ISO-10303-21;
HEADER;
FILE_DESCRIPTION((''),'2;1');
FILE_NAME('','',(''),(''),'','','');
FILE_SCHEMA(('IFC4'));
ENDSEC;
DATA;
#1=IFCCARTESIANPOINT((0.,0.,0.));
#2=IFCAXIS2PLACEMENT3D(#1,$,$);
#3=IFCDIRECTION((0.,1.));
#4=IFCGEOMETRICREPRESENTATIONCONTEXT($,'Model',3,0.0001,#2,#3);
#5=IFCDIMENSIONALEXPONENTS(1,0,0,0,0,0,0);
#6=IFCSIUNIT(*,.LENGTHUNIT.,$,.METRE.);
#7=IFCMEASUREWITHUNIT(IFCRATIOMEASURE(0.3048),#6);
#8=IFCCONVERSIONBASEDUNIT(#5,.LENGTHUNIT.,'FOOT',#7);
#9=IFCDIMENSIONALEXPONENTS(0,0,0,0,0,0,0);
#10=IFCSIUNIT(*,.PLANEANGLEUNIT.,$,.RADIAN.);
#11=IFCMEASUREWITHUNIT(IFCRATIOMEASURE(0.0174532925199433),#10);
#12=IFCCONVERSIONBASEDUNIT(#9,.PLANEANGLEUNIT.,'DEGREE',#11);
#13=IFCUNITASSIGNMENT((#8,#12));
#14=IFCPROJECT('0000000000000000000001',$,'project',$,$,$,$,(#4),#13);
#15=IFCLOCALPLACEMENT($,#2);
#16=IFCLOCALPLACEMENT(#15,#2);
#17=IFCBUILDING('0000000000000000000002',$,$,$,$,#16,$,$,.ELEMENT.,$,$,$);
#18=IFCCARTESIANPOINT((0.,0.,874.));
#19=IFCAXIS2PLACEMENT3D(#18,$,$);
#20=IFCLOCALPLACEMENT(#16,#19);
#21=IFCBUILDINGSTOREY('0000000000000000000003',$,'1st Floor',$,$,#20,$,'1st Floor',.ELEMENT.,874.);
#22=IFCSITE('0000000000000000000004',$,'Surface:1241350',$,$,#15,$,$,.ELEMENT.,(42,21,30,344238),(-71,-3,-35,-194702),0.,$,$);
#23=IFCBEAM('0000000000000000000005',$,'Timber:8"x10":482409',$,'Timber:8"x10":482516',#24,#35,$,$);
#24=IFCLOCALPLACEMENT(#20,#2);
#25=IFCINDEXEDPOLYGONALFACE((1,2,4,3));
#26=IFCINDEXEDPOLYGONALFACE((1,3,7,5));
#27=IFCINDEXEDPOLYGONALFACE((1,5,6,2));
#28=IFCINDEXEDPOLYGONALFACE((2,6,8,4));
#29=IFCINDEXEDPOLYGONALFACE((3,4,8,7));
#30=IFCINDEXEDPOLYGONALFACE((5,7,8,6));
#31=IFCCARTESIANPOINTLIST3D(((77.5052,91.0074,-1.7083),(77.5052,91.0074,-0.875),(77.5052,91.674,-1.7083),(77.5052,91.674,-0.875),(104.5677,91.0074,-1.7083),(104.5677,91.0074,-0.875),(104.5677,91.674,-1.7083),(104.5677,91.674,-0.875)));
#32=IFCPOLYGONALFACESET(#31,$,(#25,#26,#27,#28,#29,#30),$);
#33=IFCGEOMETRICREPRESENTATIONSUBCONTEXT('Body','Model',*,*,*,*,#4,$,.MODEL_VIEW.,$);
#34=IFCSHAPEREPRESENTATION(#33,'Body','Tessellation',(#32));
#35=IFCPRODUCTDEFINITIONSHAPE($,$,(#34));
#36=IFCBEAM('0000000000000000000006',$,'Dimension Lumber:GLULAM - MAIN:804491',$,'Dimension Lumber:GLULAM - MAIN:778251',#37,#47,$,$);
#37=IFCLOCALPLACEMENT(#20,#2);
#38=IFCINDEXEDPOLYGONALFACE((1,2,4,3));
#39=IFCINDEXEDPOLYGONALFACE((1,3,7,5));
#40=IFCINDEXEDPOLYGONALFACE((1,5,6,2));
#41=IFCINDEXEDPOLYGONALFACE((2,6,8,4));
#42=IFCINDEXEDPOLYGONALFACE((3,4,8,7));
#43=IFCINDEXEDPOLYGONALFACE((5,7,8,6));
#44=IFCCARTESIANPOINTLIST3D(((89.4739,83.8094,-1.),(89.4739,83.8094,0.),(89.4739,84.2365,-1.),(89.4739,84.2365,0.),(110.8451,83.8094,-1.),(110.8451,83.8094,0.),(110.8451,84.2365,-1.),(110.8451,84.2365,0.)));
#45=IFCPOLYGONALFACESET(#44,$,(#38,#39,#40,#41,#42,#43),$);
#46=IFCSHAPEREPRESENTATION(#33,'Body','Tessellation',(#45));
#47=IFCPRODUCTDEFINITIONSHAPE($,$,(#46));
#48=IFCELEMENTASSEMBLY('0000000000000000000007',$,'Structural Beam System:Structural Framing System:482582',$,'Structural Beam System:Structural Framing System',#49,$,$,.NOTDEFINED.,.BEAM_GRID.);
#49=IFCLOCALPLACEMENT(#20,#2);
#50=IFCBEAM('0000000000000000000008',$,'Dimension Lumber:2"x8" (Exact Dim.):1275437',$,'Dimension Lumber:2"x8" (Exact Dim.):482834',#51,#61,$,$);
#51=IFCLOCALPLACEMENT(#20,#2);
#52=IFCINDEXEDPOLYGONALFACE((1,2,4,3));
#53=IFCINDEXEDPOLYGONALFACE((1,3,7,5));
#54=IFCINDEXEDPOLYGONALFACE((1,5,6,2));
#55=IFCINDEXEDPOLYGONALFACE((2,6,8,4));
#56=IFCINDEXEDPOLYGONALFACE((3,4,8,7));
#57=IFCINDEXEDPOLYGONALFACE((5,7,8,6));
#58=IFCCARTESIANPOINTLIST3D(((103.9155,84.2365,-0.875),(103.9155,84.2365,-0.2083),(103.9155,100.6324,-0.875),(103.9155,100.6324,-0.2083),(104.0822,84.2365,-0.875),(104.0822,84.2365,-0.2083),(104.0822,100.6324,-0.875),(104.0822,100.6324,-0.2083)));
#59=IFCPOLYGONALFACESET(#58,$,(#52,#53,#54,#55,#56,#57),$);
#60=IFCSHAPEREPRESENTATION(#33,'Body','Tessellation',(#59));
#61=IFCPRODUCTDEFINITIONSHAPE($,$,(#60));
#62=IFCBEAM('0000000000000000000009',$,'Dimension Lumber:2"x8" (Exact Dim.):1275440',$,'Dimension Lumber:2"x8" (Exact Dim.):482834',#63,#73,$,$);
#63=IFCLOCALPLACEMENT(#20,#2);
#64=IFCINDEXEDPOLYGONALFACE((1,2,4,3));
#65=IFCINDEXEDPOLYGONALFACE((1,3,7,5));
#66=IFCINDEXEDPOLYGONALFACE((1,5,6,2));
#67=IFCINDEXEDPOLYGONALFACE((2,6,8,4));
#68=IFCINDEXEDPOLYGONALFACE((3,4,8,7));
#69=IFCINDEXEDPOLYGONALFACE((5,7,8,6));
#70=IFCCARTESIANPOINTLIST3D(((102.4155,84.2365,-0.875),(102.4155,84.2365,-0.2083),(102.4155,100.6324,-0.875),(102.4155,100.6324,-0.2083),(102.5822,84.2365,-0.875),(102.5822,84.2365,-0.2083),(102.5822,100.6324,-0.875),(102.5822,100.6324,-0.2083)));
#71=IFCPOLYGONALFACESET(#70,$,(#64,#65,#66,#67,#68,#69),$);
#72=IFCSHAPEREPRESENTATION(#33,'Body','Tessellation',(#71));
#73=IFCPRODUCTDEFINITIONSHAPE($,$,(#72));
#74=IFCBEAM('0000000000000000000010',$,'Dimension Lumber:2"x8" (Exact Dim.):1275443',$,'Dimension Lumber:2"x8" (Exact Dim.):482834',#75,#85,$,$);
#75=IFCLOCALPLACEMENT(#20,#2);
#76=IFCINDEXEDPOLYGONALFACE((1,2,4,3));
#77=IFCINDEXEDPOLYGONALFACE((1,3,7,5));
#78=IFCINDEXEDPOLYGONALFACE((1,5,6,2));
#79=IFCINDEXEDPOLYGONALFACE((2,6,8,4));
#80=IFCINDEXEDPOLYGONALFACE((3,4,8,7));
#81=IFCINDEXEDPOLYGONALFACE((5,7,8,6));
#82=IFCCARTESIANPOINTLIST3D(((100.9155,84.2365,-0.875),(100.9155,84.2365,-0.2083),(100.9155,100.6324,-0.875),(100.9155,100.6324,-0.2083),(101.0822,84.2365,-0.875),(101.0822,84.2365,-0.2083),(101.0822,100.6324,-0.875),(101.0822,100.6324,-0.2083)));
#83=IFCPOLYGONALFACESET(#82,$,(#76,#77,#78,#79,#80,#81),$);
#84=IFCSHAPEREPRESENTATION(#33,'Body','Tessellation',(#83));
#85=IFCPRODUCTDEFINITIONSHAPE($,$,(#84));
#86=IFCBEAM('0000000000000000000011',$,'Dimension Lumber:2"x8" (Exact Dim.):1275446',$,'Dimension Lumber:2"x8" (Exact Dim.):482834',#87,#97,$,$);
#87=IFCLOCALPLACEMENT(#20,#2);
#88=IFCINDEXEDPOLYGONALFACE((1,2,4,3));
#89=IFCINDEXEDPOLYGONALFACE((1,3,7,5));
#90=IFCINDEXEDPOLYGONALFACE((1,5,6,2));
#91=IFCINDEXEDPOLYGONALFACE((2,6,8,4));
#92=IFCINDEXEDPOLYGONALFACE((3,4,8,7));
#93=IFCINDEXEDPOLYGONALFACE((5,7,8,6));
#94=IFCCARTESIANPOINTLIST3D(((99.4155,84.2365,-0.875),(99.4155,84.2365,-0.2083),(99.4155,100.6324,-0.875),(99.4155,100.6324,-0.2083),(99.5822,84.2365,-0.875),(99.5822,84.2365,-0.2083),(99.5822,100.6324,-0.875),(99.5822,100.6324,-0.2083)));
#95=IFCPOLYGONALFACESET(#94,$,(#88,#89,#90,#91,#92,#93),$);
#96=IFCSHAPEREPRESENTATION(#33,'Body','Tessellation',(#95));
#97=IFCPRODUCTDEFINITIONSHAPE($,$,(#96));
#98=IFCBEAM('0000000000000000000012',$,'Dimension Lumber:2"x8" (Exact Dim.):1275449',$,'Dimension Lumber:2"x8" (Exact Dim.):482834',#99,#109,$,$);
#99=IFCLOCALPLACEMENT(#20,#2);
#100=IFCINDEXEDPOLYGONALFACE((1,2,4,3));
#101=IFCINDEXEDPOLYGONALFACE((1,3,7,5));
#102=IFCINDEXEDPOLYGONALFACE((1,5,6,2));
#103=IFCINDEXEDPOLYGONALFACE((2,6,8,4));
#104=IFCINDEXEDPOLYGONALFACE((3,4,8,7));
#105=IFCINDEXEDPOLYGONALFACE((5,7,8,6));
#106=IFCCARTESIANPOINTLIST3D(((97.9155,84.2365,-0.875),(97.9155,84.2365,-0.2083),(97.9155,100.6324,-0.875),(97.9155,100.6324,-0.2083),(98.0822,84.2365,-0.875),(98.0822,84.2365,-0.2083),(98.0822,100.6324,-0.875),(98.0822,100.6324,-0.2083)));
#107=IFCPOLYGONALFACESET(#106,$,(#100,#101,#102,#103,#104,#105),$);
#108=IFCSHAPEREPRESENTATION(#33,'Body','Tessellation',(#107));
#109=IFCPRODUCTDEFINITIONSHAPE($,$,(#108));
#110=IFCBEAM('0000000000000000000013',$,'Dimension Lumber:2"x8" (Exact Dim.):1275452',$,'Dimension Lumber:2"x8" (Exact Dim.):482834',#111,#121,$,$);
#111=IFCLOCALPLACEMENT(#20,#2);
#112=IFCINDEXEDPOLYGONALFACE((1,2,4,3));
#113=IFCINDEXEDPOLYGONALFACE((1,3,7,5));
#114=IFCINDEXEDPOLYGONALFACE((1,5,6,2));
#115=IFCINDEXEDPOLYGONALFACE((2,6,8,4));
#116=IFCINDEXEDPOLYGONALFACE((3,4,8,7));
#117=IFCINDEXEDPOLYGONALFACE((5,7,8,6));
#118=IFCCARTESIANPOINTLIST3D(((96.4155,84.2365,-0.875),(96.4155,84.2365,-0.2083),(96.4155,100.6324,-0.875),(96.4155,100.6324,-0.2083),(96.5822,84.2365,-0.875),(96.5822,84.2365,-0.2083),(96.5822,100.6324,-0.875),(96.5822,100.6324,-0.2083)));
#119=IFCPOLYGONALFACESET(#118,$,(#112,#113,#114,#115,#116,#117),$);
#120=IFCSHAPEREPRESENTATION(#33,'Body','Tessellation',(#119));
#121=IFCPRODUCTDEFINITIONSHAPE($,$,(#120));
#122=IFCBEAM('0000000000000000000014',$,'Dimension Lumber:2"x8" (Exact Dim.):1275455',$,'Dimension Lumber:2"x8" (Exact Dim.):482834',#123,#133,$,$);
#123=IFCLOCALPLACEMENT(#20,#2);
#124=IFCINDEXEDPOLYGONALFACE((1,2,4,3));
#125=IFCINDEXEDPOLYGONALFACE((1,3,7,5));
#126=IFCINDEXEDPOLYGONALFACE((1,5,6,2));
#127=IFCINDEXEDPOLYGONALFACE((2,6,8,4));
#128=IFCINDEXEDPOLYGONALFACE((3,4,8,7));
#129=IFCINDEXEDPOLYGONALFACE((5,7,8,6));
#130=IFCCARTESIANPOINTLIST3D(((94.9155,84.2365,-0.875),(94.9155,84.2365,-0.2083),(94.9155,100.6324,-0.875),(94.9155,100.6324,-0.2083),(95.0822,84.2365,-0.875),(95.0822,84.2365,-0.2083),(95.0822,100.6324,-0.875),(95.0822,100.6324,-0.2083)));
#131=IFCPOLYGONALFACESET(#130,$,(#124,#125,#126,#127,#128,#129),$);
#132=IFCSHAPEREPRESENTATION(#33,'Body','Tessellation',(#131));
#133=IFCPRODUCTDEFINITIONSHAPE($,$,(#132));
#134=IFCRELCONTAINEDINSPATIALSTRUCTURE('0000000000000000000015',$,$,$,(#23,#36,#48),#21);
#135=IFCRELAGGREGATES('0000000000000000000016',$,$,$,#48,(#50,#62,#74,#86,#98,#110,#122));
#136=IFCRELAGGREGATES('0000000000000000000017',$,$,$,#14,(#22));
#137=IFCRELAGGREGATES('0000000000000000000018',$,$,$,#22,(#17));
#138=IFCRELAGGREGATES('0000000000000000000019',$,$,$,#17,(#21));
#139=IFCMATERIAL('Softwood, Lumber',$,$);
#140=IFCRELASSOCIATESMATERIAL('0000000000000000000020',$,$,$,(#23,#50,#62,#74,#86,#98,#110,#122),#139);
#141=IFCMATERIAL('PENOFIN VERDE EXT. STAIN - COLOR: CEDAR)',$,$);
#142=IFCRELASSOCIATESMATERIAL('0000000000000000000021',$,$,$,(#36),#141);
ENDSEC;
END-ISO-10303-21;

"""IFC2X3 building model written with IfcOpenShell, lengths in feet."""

from ifc_helpers import new_model, entity, si_unit, converted_unit, direction, frame, frame_2d, origin, place, context, subcontext, project, spatial, rectangle, extrude, material, element, aggregate, save


model = new_model("IFC2X3")

# Units and contexts
model_context = context("Model", 3, precision=0.0001, world=origin(), true_north=direction((0.0, 1.0)))
body_context = subcontext(model_context, "Body", "Model", "MODEL_VIEW")
ifc_project = project(units=[converted_unit("LENGTHUNIT", "FOOT", entity("IfcRatioMeasure", 0.3048), si_unit("LENGTHUNIT", "METRE"), dimensions=[1, 0, 0, 0, 0, 0, 0]), converted_unit("PLANEANGLEUNIT", "DEGREE", entity("IfcRatioMeasure", 0.0174532925199433), si_unit("PLANEANGLEUNIT", "RADIAN"), dimensions=[0, 0, 0, 0, 0, 0, 0])], contexts=[model_context])

# Site, building, storey
site_placement = place(None, origin())
site = spatial("IfcSite", under=ifc_project, at=site_placement, Name="Surface:1241350", CompositionType="ELEMENT", RefLatitude=(42, 21, 30, 344238), RefLongitude=(-71, -3, -35, -194702), RefElevation=0.0)
building_placement = place(site_placement, origin())
building = spatial("IfcBuilding", under=site, at=building_placement, CompositionType="ELEMENT")
storey_placement = place(building_placement, frame((0.0, 0.0, 874.0)))
storey = spatial("IfcBuildingStorey", under=building, at=storey_placement, Name="1st Floor", LongName="1st Floor", CompositionType="ELEMENT", Elevation=874.0)

# Beams
ifc_material_1 = material(Name="Softwood, Lumber")
beam_1_placement = place(storey_placement, frame((77.1719, 91.3407, 0.0)))
element("IfcBeam", 1, at=beam_1_placement, inside=storey, material=ifc_material_1, Name="Timber:8\"x10\":482409", ObjectType="Timber:8\"x10\":482516", context=body_context, shape_type="SweptSolid", body=[
    extrude(rectangle(XDim=0.8333, YDim=0.6667, at=frame_2d((0.0, 0.0), x_axis=(1.0, 0.0))), frame((0.3333, 0.0, -1.2917), z_axis=(1.0, 0.0, 0.0), x_axis=(0.0, 0.0, -1.0)), (0.0, 0.0, 1.0), 27.0625),
])
ifc_material_2 = material(Name="PENOFIN VERDE EXT. STAIN - COLOR: CEDAR)")
beam_2_placement = place(storey_placement, frame((89.4739, 84.023, 0.0)))
element("IfcBeam", 2, at=beam_2_placement, inside=storey, material=ifc_material_2, Name="Dimension Lumber:GLULAM - MAIN:804491", ObjectType="Dimension Lumber:GLULAM - MAIN:778251", context=body_context, shape_type="SweptSolid", body=[
    extrude(rectangle(XDim=1.0, YDim=0.4271, at=frame_2d((0.0, 0.0), x_axis=(1.0, 0.0))), frame((0.0, 0.0, -0.5), z_axis=(1.0, 0.0, 0.0), x_axis=(0.0, 0.0, -1.0)), (0.0, 0.0, 1.0), 21.3712),
])

# Element assembly, beams
assembly_placement = place(storey_placement, origin())
assembly = element("IfcElementAssembly", 3, at=assembly_placement, inside=storey, Name="Structural Beam System:Structural Framing System:482582", ObjectType="Structural Beam System:Structural Framing System", AssemblyPlace="NOTDEFINED", PredefinedType="BEAM_GRID")
beam_3_placement = place(assembly_placement, frame((103.9988, 100.9657, 0.0), z_axis=(0.0, 0.0, 1.0), x_axis=(0.0, -1.0, 0.0)))
beam_3 = element("IfcBeam", 4, at=beam_3_placement, material=ifc_material_1, Name="Dimension Lumber:2\"x8\" (Exact Dim.):1275437", ObjectType="Dimension Lumber:2\"x8\" (Exact Dim.):482834", context=body_context, shape_type="SweptSolid", body=[
    extrude(rectangle(XDim=0.6667, YDim=0.1667, at=frame_2d((0.0, 0.0), x_axis=(1.0, 0.0))), frame((0.3333, 0.0, -0.5417), z_axis=(1.0, 0.0, 0.0), x_axis=(0.0, 0.0, -1.0)), (0.0, 0.0, 1.0), 16.3958),
])
beam_4_placement = place(assembly_placement, frame((102.4988, 100.9657, 0.0), z_axis=(0.0, 0.0, 1.0), x_axis=(0.0, -1.0, 0.0)))
beam_4 = element("IfcBeam", 5, at=beam_4_placement, material=ifc_material_1, Name="Dimension Lumber:2\"x8\" (Exact Dim.):1275440", ObjectType="Dimension Lumber:2\"x8\" (Exact Dim.):482834", context=body_context, shape_type="SweptSolid", body=[
    extrude(rectangle(XDim=0.6667, YDim=0.1667, at=frame_2d((0.0, 0.0), x_axis=(1.0, 0.0))), frame((0.3333, 0.0, -0.5417), z_axis=(1.0, 0.0, 0.0), x_axis=(0.0, 0.0, -1.0)), (0.0, 0.0, 1.0), 16.3958),
])
beam_5_placement = place(assembly_placement, frame((100.9988, 100.9657, 0.0), z_axis=(0.0, 0.0, 1.0), x_axis=(0.0, -1.0, 0.0)))
beam_5 = element("IfcBeam", 6, at=beam_5_placement, material=ifc_material_1, Name="Dimension Lumber:2\"x8\" (Exact Dim.):1275443", ObjectType="Dimension Lumber:2\"x8\" (Exact Dim.):482834", context=body_context, shape_type="SweptSolid", body=[
    extrude(rectangle(XDim=0.6667, YDim=0.1667, at=frame_2d((0.0, 0.0), x_axis=(1.0, 0.0))), frame((0.3333, 0.0, -0.5417), z_axis=(1.0, 0.0, 0.0), x_axis=(0.0, 0.0, -1.0)), (0.0, 0.0, 1.0), 16.3958),
])
beam_6_placement = place(assembly_placement, frame((99.4988, 100.9657, 0.0), z_axis=(0.0, 0.0, 1.0), x_axis=(0.0, -1.0, 0.0)))
beam_6 = element("IfcBeam", 7, at=beam_6_placement, material=ifc_material_1, Name="Dimension Lumber:2\"x8\" (Exact Dim.):1275446", ObjectType="Dimension Lumber:2\"x8\" (Exact Dim.):482834", context=body_context, shape_type="SweptSolid", body=[
    extrude(rectangle(XDim=0.6667, YDim=0.1667, at=frame_2d((0.0, 0.0), x_axis=(1.0, 0.0))), frame((0.3333, 0.0, -0.5417), z_axis=(1.0, 0.0, 0.0), x_axis=(0.0, 0.0, -1.0)), (0.0, 0.0, 1.0), 16.3958),
])
beam_7_placement = place(assembly_placement, frame((97.9988, 100.9657, 0.0), z_axis=(0.0, 0.0, 1.0), x_axis=(0.0, -1.0, 0.0)))
beam_7 = element("IfcBeam", 8, at=beam_7_placement, material=ifc_material_1, Name="Dimension Lumber:2\"x8\" (Exact Dim.):1275449", ObjectType="Dimension Lumber:2\"x8\" (Exact Dim.):482834", context=body_context, shape_type="SweptSolid", body=[
    extrude(rectangle(XDim=0.6667, YDim=0.1667, at=frame_2d((0.0, 0.0), x_axis=(1.0, 0.0))), frame((0.3333, 0.0, -0.5417), z_axis=(1.0, 0.0, 0.0), x_axis=(0.0, 0.0, -1.0)), (0.0, 0.0, 1.0), 16.3958),
])
beam_8_placement = place(assembly_placement, frame((96.4988, 100.9657, 0.0), z_axis=(0.0, 0.0, 1.0), x_axis=(0.0, -1.0, 0.0)))
beam_8 = element("IfcBeam", 9, at=beam_8_placement, material=ifc_material_1, Name="Dimension Lumber:2\"x8\" (Exact Dim.):1275452", ObjectType="Dimension Lumber:2\"x8\" (Exact Dim.):482834", context=body_context, shape_type="SweptSolid", body=[
    extrude(rectangle(XDim=0.6667, YDim=0.1667, at=frame_2d((0.0, 0.0), x_axis=(1.0, 0.0))), frame((0.3333, 0.0, -0.5417), z_axis=(1.0, 0.0, 0.0), x_axis=(0.0, 0.0, -1.0)), (0.0, 0.0, 1.0), 16.3958),
])
beam_9_placement = place(assembly_placement, frame((94.9988, 100.9657, 0.0), z_axis=(0.0, 0.0, 1.0), x_axis=(0.0, -1.0, 0.0)))
beam_9 = element("IfcBeam", 10, at=beam_9_placement, material=ifc_material_1, Name="Dimension Lumber:2\"x8\" (Exact Dim.):1275455", ObjectType="Dimension Lumber:2\"x8\" (Exact Dim.):482834", context=body_context, shape_type="SweptSolid", body=[
    extrude(rectangle(XDim=0.6667, YDim=0.1667, at=frame_2d((0.0, 0.0), x_axis=(1.0, 0.0))), frame((0.3333, 0.0, -0.5417), z_axis=(1.0, 0.0, 0.0), x_axis=(0.0, 0.0, -1.0)), (0.0, 0.0, 1.0), 16.3958),
])
aggregate(assembly, [beam_3, beam_4, beam_5, beam_6, beam_7, beam_8, beam_9])

save(model, "model.ifc")
